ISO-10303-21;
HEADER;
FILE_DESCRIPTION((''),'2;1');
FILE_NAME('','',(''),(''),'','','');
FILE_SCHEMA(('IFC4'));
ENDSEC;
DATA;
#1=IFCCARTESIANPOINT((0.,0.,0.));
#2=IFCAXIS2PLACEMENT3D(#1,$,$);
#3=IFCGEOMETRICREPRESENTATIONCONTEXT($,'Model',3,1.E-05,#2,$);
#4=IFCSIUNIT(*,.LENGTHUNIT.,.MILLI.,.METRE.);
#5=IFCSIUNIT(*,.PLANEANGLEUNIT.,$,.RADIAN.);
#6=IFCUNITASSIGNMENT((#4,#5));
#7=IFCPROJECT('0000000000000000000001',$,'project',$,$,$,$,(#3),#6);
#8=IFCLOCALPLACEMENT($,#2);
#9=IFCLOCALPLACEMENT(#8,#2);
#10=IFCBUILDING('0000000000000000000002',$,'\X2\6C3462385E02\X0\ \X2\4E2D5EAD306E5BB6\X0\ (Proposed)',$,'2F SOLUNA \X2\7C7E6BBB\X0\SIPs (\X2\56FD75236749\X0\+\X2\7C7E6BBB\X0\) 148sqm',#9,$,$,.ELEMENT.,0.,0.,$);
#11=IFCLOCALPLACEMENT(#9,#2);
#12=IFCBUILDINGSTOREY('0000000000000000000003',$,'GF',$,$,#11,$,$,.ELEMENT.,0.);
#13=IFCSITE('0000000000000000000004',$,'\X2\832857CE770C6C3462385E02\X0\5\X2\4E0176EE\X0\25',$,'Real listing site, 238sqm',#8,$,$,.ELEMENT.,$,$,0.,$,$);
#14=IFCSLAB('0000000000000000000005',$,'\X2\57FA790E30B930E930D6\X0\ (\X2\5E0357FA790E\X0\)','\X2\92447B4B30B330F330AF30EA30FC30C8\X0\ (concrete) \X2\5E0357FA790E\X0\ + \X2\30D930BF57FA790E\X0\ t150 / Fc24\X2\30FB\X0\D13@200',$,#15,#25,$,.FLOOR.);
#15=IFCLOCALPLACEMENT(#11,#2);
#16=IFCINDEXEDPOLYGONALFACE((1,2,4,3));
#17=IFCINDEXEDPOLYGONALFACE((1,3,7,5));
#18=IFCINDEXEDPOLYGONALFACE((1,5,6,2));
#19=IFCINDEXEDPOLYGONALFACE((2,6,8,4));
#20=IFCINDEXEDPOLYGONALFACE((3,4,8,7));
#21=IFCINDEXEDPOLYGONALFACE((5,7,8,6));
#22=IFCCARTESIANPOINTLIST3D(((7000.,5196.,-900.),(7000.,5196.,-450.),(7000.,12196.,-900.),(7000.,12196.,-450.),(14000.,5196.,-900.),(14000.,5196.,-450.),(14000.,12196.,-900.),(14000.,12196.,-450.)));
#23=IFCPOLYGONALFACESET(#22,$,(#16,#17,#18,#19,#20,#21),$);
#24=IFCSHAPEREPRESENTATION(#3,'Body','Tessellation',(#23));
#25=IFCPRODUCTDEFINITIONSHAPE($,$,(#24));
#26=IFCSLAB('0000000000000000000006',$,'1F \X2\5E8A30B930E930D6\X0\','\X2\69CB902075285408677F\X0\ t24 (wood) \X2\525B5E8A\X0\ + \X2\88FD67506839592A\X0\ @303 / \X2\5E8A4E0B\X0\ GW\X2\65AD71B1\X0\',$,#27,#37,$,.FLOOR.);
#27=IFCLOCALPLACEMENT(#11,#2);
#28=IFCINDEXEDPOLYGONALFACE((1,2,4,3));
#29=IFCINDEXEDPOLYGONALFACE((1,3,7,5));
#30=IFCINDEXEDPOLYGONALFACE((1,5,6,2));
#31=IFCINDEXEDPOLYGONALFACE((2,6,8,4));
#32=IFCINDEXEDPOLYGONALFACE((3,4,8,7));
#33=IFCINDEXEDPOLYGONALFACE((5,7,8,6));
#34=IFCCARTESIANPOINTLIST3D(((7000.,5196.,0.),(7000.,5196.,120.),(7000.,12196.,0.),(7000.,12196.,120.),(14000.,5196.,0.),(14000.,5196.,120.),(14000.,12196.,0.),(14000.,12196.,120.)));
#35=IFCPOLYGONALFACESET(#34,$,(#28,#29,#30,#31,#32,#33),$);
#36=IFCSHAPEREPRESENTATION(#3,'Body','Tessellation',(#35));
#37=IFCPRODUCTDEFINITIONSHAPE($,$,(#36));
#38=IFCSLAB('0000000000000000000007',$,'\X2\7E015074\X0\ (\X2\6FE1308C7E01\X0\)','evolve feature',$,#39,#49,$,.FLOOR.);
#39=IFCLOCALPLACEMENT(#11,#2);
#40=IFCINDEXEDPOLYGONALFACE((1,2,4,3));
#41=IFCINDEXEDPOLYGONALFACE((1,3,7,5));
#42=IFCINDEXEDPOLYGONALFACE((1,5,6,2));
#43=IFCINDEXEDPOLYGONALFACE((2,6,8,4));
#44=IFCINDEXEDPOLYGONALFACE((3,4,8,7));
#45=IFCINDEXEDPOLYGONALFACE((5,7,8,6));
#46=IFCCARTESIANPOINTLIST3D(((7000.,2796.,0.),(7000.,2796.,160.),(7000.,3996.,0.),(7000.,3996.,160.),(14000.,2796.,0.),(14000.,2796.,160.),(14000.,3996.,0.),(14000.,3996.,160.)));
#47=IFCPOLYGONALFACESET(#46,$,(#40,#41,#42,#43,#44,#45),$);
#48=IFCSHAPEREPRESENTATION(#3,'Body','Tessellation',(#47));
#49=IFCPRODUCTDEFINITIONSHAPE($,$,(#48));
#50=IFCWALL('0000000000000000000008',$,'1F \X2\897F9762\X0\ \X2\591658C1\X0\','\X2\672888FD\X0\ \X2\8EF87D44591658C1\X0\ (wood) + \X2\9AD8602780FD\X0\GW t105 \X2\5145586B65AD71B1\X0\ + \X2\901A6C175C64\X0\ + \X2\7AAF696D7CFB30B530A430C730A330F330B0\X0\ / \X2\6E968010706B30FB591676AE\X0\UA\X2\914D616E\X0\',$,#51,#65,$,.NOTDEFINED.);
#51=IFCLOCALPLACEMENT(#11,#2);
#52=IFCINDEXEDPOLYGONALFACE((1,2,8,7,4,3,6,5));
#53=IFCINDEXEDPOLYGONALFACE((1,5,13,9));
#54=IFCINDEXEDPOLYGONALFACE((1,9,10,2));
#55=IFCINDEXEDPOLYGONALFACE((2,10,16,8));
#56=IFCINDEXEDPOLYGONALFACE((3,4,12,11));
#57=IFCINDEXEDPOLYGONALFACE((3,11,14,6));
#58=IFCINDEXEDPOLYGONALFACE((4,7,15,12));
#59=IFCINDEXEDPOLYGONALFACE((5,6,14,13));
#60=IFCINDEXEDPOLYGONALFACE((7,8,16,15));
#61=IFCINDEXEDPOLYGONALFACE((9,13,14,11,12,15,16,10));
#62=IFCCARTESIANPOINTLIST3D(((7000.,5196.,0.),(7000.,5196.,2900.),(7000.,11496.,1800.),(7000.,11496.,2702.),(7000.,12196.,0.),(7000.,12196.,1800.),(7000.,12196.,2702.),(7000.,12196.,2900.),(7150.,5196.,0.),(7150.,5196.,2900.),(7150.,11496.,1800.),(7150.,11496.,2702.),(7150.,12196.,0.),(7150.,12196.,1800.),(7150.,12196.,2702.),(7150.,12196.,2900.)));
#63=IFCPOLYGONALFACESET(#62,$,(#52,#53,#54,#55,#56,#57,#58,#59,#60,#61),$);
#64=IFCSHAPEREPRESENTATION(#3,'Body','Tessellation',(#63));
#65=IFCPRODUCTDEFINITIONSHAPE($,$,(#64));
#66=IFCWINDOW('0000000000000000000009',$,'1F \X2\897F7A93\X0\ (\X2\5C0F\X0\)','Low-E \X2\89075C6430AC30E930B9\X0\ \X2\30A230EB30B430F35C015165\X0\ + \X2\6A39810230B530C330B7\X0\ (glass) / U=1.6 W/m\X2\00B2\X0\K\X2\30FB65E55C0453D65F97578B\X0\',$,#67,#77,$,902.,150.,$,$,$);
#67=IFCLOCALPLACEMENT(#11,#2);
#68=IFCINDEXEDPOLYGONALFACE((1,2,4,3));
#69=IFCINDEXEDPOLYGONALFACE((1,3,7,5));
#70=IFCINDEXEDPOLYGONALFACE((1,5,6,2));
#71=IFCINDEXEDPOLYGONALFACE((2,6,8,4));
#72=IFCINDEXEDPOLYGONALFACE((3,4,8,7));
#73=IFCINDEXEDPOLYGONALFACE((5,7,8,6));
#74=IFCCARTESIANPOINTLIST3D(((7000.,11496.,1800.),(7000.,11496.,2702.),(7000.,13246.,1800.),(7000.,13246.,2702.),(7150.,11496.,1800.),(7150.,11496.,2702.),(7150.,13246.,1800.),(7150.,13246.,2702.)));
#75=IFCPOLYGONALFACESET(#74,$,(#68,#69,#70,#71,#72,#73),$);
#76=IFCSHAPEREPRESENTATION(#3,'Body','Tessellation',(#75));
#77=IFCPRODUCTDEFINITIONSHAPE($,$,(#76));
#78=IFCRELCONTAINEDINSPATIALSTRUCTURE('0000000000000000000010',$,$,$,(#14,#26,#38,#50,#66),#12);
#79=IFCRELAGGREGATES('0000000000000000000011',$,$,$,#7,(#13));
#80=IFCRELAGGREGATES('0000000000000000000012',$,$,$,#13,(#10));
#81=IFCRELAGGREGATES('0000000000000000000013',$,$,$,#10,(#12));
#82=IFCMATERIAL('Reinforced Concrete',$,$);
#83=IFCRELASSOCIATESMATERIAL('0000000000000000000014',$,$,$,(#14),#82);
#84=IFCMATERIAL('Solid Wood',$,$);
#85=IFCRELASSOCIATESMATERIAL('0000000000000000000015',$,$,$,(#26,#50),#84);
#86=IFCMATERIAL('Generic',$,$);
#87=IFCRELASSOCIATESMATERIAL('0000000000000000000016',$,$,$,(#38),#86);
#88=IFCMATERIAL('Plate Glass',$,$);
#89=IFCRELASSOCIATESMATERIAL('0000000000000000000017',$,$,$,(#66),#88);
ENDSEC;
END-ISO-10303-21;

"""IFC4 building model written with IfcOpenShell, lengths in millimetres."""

from ifc_helpers import new_model, si_unit, frame, frame_2d, origin, place, context, project, spatial, rectangle, extrude, material, element, fill, save


model = new_model("IFC4")

# Units and contexts
model_context = context("Model", 3, precision=1e-05, world=origin())
ifc_project = project(units=[si_unit("LENGTHUNIT", "METRE", prefix="MILLI"), si_unit("PLANEANGLEUNIT", "RADIAN")], contexts=[model_context])

# Site, building, storey
site_placement = place(None, origin())
site = spatial("IfcSite", under=ifc_project, at=site_placement, Name="茨城県水戸市5丁目25", ObjectType="Real listing site, 238sqm", CompositionType="ELEMENT", RefElevation=0.0)
building_placement = place(site_placement, origin())
building = spatial("IfcBuilding", under=site, at=building_placement, Name="水戸市 中庭の家 (Proposed)", ObjectType="2F SOLUNA 籾殻SIPs (国産杉+籾殻) 148sqm", CompositionType="ELEMENT", ElevationOfRefHeight=0.0, ElevationOfTerrain=0.0)
storey_placement = place(building_placement, origin())
storey = spatial("IfcBuildingStorey", under=building, at=storey_placement, Name="GF", CompositionType="ELEMENT", Elevation=0.0)

# Slabs
ifc_material_1 = material(Name="Reinforced Concrete")
slab_1_placement = place(storey_placement, frame((3500.0, 2598.0, -450.0)))
element("IfcSlab", 1, at=slab_1_placement, inside=storey, material=ifc_material_1, Name="基礎スラブ (布基礎)", Description="鉄筋コンクリート (concrete) 布基礎 + ベタ基礎 t150 / Fc24・D13@200", PredefinedType="FLOOR", context=model_context, shape_type="SweptSolid", body=[
    extrude(rectangle(XDim=7000.0, YDim=7000.0, at=frame_2d((3500.0, 3500.0))), frame((3500.0, 2598.0, -450.0)), (0.0, 0.0, 1.0), 450.0),
])
ifc_material_2 = material(Name="Solid Wood")
slab_2_placement = place(storey_placement, frame((3500.0, 2598.0, 0.0)))
element("IfcSlab", 2, at=slab_2_placement, inside=storey, material=ifc_material_2, Name="1F 床スラブ", Description="構造用合板 t24 (wood) 剛床 + 製材根太 @303 / 床下 GW断熱", PredefinedType="FLOOR", context=model_context, shape_type="SweptSolid", body=[
    extrude(rectangle(XDim=7000.0, YDim=7000.0, at=frame_2d((3500.0, 3500.0))), frame((3500.0, 2598.0, 0.0)), (0.0, 0.0, 1.0), 120.0),
])
ifc_material_3 = material(Name="Generic")
slab_3_placement = place(storey_placement, frame((3500.0, 1398.0, 0.0)))
element("IfcSlab", 3, at=slab_3_placement, inside=storey, material=ifc_material_3, Name="縁側 (濡れ縁)", Description="evolve feature", PredefinedType="FLOOR", context=model_context, shape_type="SweptSolid", body=[
    extrude(rectangle(XDim=7000.0, YDim=1200.0, at=frame_2d((3500.0, 600.0))), frame((3500.0, 1398.0, 0.0)), (0.0, 0.0, 1.0), 160.0),
])

# Shared definitions
ifc_material_4 = material(Name="Plate Glass")

# Wall, opening, window
wall_1_placement = place(storey_placement, frame((3500.0, 2598.0, 0.0)))
wall_1 = element("IfcWall", 4, at=wall_1_placement, inside=storey, material=ifc_material_2, Name="1F 西面 外壁", Description="木製 軸組外壁 (wood) + 高性能GW t105 充填断熱 + 通気層 + 窯業系サイディング / 準耐火・外皮UA配慮", PredefinedType="NOTDEFINED", context=model_context, shape_type="SweptSolid", body=[
    extrude(rectangle(XDim=150.0, YDim=7000.0, at=frame_2d((75.0, 3500.0))), frame((3500.0, 2598.0, 0.0)), (0.0, 0.0, 1.0), 2900.0),
])
opening_1_placement = place(storey_placement, frame((3500.0, 5748.0, 900.0)))
opening_1 = element("IfcOpeningElement", 5, at=opening_1_placement, cuts=wall_1, PredefinedType="NOTDEFINED", context=model_context, shape_type="SweptSolid", body=[
    extrude(rectangle(XDim=150.0, YDim=1750.0, at=frame_2d((75.0, 875.0))), frame((3500.0, 5748.0, 900.0)), (0.0, 0.0, 1.0), 902.0),
])
window_1_placement = place(storey_placement, frame((3500.0, 5748.0, 900.0)))
window_1 = element("IfcWindow", 6, at=window_1_placement, inside=storey, material=ifc_material_4, Name="1F 西窓 (小)", Description="Low-E 複層ガラス アルゴン封入 + 樹脂サッシ (glass) / U=1.6 W/m²K・日射取得型", OverallHeight=902.0, OverallWidth=150.0, context=model_context, shape_type="SweptSolid", body=[
    extrude(rectangle(XDim=150.0, YDim=1750.0, at=frame_2d((75.0, 875.0))), frame((3500.0, 5748.0, 900.0)), (0.0, 0.0, 1.0), 902.0),
])
fill(opening_1, window_1)

save(model, "model.ifc")
